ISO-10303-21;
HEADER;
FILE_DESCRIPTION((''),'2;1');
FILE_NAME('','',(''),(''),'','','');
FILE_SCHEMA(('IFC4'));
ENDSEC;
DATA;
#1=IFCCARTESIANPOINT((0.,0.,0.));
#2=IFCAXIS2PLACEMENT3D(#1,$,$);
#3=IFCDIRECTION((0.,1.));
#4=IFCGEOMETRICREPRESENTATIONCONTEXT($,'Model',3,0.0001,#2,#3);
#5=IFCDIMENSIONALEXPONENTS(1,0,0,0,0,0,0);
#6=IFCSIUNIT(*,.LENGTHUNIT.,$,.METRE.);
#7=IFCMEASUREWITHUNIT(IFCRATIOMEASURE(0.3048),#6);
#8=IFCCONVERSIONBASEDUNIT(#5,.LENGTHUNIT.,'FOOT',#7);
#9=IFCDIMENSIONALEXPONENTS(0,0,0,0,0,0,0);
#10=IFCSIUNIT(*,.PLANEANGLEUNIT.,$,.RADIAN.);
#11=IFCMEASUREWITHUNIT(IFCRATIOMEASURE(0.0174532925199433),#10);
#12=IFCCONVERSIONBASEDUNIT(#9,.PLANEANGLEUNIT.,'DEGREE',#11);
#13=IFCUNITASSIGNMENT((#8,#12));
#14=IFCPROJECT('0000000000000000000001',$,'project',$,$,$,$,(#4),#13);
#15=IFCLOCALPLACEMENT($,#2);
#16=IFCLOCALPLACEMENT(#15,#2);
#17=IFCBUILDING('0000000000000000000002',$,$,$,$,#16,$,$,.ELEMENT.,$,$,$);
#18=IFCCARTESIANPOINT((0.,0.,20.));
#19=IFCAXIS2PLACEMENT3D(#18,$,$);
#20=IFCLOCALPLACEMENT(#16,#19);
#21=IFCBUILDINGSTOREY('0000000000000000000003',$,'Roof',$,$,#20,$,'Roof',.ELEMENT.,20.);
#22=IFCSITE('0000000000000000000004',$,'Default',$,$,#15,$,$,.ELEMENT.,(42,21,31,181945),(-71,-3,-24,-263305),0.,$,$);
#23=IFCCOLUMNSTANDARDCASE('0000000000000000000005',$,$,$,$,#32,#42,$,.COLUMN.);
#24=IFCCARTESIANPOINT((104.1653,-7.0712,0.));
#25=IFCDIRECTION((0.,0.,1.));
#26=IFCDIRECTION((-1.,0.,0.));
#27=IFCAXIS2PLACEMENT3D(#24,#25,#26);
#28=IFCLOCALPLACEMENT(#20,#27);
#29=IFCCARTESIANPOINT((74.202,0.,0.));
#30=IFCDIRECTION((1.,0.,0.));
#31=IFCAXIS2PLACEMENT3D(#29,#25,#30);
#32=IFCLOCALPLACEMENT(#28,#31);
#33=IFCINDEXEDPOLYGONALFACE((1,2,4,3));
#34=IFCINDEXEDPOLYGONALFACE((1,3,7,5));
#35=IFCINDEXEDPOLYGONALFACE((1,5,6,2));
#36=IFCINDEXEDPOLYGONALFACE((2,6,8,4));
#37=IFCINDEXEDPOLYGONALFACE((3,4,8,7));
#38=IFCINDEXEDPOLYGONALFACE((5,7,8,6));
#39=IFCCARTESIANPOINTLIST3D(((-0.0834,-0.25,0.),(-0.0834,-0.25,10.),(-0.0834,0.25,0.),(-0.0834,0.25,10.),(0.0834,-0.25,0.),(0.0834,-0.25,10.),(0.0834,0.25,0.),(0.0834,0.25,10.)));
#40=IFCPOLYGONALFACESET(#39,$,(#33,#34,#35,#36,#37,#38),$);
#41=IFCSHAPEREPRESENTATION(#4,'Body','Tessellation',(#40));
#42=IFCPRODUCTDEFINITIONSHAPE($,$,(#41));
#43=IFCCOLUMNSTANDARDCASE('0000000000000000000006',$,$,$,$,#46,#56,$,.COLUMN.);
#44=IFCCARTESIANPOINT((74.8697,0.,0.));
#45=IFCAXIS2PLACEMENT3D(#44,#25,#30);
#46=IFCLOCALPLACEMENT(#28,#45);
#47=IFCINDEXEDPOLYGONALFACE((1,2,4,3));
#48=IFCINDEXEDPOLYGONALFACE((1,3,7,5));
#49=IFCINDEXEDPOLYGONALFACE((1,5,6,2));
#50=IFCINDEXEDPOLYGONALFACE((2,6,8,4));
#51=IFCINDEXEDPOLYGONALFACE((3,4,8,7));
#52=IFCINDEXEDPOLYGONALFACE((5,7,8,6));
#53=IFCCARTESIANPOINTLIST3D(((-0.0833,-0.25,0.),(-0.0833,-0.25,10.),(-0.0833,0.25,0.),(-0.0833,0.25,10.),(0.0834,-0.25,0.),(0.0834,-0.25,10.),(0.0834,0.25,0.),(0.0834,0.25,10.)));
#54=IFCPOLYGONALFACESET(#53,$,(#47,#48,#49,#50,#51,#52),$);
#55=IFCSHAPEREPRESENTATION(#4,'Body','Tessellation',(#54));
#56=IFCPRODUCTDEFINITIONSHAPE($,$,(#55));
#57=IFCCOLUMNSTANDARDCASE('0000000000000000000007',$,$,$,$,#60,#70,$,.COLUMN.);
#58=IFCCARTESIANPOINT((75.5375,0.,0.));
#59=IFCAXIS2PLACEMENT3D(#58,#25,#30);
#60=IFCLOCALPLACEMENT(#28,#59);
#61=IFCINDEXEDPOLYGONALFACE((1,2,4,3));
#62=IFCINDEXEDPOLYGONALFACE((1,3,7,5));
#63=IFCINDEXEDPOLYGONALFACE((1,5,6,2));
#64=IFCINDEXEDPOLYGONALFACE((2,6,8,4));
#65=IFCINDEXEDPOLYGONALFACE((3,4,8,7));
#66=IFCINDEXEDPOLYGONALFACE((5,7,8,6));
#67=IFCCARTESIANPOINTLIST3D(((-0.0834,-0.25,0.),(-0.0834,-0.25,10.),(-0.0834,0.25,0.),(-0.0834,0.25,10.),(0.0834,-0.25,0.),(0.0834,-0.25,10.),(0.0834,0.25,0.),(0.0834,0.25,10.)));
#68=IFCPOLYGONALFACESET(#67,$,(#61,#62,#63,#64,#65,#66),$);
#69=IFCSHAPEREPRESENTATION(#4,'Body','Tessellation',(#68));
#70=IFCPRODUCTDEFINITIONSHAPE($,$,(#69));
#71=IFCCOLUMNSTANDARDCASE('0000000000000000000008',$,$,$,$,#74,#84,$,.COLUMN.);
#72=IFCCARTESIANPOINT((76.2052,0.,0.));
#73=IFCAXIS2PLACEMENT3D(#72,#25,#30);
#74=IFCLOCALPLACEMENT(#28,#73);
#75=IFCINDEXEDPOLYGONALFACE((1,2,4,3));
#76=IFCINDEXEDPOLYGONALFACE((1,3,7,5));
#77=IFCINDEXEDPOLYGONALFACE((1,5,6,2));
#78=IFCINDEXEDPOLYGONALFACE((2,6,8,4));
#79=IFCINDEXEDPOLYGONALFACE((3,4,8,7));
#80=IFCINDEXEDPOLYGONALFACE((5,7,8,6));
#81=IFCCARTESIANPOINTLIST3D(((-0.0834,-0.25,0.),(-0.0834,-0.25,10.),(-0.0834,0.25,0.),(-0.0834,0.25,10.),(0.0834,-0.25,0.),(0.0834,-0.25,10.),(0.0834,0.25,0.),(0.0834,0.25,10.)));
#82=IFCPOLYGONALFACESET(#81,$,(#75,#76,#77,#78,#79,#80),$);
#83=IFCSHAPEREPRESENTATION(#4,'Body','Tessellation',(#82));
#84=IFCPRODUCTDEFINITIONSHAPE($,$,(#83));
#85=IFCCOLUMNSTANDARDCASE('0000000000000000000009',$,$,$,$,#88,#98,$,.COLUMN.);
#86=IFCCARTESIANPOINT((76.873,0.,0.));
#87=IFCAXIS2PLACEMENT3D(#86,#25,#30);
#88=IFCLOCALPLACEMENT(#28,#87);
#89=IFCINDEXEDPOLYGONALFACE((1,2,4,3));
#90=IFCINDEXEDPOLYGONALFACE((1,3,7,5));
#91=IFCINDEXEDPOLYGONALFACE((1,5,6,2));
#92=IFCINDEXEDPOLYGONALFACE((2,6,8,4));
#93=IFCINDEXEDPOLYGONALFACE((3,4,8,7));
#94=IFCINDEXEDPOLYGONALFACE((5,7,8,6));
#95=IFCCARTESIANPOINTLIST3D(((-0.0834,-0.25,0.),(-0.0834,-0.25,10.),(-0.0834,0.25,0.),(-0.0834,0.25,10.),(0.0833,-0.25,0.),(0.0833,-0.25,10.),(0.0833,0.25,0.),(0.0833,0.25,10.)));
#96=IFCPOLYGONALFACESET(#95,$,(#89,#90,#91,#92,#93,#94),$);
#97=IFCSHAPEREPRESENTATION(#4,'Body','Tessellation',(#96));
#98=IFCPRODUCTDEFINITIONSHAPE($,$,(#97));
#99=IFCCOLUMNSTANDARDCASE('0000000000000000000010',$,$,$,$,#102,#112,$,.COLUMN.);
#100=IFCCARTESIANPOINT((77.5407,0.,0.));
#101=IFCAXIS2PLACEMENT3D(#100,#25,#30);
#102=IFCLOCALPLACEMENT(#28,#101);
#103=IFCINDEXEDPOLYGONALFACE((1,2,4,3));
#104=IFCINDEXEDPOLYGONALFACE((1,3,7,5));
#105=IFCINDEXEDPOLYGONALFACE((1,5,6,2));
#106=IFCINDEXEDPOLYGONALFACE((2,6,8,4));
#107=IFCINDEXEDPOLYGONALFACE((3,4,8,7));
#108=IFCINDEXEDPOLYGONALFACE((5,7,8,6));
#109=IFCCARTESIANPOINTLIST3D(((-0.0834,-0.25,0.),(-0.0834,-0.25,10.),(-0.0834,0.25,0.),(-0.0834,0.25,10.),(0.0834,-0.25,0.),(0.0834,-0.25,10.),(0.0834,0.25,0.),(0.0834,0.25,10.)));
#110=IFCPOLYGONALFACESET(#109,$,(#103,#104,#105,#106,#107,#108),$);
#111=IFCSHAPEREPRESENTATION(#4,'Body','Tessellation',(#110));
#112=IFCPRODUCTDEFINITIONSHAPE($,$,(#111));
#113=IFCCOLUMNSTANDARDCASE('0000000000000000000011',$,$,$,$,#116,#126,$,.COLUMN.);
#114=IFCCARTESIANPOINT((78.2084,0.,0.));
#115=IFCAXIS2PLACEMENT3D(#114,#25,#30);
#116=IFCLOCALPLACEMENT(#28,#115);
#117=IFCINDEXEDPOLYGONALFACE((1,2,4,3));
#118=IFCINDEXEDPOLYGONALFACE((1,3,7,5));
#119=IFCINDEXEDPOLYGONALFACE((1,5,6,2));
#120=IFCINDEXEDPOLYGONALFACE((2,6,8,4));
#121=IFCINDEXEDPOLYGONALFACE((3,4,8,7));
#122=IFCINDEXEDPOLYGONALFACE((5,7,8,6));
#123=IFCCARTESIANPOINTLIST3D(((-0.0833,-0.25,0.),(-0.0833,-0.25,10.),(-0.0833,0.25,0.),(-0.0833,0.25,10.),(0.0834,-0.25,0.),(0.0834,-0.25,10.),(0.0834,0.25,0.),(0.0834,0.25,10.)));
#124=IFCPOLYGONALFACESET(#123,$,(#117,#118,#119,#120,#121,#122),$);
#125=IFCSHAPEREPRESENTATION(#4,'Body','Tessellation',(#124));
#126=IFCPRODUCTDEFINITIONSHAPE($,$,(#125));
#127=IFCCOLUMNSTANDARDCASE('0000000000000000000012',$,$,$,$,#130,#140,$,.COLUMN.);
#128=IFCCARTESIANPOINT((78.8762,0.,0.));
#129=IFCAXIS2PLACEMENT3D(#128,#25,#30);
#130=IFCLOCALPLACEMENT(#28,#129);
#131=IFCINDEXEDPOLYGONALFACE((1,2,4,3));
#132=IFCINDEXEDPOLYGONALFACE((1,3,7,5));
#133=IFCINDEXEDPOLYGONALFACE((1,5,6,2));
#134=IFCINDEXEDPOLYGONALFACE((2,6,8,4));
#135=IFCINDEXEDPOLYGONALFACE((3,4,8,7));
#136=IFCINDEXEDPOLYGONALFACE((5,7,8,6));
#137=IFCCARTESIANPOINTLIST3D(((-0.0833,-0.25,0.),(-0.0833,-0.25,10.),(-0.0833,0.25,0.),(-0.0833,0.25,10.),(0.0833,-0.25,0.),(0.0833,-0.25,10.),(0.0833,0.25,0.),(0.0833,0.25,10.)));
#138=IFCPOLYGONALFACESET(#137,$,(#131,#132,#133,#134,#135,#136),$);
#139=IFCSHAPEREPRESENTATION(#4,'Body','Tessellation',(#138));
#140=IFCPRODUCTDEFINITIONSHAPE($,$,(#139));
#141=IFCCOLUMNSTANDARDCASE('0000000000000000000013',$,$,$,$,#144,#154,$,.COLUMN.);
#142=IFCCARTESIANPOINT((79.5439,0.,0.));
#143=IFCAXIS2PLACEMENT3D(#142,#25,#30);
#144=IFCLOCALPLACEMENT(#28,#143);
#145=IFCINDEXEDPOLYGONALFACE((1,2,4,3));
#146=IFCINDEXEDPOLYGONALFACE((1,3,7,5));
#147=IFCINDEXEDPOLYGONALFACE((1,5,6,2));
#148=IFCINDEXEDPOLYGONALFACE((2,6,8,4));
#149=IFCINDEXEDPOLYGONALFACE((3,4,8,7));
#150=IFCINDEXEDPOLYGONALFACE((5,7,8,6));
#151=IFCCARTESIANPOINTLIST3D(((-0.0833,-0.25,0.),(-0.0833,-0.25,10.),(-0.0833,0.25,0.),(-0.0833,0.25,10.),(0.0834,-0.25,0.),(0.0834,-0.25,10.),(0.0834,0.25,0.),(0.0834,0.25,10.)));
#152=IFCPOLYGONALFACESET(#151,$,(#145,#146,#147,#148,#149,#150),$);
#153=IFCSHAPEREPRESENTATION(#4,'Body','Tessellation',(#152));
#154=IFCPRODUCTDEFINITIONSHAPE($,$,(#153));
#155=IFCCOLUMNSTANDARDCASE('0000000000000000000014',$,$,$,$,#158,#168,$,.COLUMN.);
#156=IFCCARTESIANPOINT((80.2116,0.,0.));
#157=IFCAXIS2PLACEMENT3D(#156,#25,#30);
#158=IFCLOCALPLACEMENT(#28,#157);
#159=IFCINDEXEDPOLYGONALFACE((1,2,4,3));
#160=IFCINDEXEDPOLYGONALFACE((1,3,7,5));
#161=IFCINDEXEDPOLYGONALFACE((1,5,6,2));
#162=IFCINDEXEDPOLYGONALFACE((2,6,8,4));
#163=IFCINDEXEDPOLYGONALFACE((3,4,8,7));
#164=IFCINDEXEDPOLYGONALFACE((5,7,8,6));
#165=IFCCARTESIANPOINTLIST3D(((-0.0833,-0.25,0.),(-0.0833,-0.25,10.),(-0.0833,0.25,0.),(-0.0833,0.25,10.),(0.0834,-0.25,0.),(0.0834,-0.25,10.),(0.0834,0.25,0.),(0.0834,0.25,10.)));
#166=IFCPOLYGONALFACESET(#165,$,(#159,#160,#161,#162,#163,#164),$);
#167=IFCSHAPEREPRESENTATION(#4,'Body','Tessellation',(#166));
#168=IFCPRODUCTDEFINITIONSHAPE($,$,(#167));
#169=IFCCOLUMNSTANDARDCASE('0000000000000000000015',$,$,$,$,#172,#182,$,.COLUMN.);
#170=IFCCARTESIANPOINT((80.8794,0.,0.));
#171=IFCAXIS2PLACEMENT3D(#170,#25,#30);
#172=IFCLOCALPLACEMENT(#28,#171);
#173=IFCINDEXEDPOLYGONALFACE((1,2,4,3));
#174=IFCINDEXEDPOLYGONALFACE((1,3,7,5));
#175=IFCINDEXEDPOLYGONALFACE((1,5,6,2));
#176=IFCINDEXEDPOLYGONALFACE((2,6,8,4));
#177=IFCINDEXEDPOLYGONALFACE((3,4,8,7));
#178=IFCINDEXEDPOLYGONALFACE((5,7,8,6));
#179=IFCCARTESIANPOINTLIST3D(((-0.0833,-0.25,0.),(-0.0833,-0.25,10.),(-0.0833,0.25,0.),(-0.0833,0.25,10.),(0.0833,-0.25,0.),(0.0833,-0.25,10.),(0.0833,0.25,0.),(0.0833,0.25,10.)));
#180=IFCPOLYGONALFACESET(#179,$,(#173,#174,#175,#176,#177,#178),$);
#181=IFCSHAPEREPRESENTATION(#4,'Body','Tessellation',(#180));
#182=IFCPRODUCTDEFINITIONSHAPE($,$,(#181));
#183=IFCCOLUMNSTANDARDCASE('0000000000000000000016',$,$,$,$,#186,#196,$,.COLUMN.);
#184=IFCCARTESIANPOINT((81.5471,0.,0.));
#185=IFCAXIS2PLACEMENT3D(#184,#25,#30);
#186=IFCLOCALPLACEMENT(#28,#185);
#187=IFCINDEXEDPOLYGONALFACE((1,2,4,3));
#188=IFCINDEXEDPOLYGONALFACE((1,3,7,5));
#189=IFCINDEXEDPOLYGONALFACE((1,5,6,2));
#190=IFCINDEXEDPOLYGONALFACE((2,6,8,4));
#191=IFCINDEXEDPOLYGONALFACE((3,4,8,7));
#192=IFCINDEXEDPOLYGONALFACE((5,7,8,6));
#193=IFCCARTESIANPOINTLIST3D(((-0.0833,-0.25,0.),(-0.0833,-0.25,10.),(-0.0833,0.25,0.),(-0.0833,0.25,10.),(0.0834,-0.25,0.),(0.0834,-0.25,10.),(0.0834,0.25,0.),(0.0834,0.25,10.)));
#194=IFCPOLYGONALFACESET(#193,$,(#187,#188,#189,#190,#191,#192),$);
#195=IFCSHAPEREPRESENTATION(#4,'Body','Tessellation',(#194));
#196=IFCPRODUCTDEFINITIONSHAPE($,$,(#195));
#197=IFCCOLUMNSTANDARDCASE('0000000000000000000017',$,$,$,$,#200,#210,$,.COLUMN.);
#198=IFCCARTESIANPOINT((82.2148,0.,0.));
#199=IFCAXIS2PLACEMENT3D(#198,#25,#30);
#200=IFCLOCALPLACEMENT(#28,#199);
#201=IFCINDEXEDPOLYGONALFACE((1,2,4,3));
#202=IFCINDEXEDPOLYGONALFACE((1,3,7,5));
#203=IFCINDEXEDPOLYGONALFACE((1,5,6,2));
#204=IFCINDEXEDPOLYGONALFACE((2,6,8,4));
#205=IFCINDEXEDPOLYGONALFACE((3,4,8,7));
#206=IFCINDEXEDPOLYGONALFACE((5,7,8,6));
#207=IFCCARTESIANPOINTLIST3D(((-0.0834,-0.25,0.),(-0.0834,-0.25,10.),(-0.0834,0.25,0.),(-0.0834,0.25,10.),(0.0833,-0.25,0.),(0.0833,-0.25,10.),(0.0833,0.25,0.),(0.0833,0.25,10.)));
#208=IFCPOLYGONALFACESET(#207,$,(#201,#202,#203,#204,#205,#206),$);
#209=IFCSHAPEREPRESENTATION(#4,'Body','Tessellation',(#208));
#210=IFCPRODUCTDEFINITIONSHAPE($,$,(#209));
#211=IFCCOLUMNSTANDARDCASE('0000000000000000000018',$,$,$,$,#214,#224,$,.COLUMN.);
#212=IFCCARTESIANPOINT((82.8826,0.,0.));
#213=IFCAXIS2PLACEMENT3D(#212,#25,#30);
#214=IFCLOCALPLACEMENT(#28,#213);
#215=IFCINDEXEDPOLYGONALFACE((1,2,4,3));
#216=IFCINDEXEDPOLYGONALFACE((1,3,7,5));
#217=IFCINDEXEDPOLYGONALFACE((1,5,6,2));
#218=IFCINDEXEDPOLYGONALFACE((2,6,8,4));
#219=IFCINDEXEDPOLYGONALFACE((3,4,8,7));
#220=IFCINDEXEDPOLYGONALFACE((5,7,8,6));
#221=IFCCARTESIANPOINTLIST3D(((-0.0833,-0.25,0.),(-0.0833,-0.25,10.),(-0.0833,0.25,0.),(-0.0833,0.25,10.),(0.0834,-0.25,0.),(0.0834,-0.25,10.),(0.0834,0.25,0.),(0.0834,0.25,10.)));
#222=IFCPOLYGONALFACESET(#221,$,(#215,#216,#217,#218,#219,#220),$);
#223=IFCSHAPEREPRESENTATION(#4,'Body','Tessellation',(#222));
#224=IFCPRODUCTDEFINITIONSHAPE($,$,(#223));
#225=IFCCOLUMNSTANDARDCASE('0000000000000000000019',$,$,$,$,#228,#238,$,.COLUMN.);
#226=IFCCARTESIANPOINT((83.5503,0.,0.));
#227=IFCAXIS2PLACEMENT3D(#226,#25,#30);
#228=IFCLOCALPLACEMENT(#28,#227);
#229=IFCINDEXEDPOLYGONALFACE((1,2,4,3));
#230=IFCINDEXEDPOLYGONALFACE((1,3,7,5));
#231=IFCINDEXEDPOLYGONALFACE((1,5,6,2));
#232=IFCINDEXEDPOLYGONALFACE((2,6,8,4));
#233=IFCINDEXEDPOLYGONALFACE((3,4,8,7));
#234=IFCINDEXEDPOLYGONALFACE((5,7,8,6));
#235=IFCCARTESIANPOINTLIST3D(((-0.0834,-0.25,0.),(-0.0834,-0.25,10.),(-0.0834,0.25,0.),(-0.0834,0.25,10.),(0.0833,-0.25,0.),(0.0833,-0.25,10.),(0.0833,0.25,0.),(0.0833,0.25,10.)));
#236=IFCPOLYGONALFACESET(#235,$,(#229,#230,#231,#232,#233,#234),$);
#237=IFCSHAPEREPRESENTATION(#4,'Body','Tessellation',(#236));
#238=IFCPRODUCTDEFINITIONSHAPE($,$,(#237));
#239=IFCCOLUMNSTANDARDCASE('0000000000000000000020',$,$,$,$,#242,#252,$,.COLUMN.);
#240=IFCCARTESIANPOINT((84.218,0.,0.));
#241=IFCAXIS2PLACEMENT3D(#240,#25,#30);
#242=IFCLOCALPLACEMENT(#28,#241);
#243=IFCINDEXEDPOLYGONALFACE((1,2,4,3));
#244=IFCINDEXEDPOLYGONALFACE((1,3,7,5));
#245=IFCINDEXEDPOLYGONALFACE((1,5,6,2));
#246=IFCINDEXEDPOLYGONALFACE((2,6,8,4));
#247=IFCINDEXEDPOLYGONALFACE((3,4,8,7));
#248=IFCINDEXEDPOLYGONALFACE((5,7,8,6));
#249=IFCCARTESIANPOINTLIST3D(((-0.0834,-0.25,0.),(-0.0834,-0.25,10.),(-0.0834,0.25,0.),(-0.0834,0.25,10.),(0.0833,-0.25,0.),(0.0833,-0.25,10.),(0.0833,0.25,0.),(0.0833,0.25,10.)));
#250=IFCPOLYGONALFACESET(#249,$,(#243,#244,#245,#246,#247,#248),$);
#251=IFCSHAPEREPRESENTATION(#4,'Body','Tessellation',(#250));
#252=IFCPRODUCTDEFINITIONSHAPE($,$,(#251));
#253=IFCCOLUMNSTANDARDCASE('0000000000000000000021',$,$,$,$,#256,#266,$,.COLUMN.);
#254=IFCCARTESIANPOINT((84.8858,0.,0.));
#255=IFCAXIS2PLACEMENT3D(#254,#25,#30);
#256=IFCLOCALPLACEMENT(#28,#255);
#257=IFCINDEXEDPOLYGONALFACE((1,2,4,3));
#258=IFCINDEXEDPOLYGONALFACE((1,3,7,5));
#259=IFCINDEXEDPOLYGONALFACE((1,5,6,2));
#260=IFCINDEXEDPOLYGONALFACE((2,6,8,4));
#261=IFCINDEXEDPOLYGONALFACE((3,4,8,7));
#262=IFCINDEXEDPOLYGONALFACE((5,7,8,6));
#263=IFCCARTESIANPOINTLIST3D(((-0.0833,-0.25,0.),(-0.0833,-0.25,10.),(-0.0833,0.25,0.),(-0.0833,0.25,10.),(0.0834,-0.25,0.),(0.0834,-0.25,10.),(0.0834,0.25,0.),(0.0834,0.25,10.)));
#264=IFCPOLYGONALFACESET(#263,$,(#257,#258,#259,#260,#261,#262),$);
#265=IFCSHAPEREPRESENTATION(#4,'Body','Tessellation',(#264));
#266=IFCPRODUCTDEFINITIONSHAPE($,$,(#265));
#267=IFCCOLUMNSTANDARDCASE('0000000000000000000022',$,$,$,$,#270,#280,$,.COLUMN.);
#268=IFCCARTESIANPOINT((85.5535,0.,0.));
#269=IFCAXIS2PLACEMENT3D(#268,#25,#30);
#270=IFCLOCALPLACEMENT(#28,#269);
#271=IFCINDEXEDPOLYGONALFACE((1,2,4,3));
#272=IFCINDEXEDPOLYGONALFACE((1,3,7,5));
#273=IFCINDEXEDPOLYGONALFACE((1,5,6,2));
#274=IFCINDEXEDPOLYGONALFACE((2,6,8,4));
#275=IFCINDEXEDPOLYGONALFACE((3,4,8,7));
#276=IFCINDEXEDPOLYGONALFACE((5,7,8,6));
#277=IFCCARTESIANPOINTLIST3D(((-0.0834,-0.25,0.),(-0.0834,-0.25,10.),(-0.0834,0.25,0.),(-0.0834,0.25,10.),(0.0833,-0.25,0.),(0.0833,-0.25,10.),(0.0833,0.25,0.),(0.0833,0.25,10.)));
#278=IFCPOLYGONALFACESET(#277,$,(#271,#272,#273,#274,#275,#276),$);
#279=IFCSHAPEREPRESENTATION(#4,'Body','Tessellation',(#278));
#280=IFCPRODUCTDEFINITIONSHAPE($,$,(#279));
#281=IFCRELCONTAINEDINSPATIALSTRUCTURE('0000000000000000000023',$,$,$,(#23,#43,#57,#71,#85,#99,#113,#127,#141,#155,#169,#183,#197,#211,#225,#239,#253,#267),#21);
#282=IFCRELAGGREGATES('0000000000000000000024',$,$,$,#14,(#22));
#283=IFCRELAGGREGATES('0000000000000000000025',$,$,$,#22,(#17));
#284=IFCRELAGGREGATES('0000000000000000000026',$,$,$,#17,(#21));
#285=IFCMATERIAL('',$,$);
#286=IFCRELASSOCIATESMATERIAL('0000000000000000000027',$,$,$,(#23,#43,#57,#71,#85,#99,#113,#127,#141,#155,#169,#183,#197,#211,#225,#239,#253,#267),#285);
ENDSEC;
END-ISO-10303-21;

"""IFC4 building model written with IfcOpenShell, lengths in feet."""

from ifc_helpers import new_model, entity, si_unit, converted_unit, direction, frame, origin, place, context, project, spatial, rectangle, extrude, material, element, save


model = new_model("IFC4")

# Units and contexts
model_context = context("Model", 3, precision=0.0001, world=origin(), true_north=direction((0.0, 1.0)))
ifc_project = project(units=[converted_unit("LENGTHUNIT", "FOOT", entity("IfcRatioMeasure", 0.3048), si_unit("LENGTHUNIT", "METRE"), dimensions=[1, 0, 0, 0, 0, 0, 0]), converted_unit("PLANEANGLEUNIT", "DEGREE", entity("IfcRatioMeasure", 0.0174532925199433), si_unit("PLANEANGLEUNIT", "RADIAN"), dimensions=[0, 0, 0, 0, 0, 0, 0])], contexts=[model_context])

# Site, building, storey
site_placement = place(None, origin())
site = spatial("IfcSite", under=ifc_project, at=site_placement, Name="Default", CompositionType="ELEMENT", RefLatitude=(42, 21, 31, 181945), RefLongitude=(-71, -3, -24, -263305), RefElevation=0.0)
building_placement = place(site_placement, origin())
building = spatial("IfcBuilding", under=site, at=building_placement, CompositionType="ELEMENT")
storey_placement = place(building_placement, frame((0.0, 0.0, 20.0)))
storey = spatial("IfcBuildingStorey", under=building, at=storey_placement, Name="Roof", LongName="Roof", CompositionType="ELEMENT", Elevation=20.0)

# Columns
ifc_material_1 = material(Name="")
placement_1 = place(storey_placement, frame((104.1653, -7.0712, 0.0), z_axis=(0.0, 0.0, 1.0), x_axis=(-1.0, 0.0, 0.0)))
for number, where, z_axis, x_axis in (
    (1, (74.202, 0.0, 0.0), (0.0, 0.0, 1.0), (1.0, 0.0, 0.0)),
    (2, (74.8697, 0.0, 0.0), (0.0, 0.0, 1.0), (1.0, 0.0, 0.0)),
    (3, (75.5375, 0.0, 0.0), (0.0, 0.0, 1.0), (1.0, 0.0, 0.0)),
    (4, (76.2052, 0.0, 0.0), (0.0, 0.0, 1.0), (1.0, 0.0, 0.0)),
    (5, (76.873, 0.0, 0.0), (0.0, 0.0, 1.0), (1.0, 0.0, 0.0)),
    (6, (77.5407, 0.0, 0.0), (0.0, 0.0, 1.0), (1.0, 0.0, 0.0)),
    (7, (78.2084, 0.0, 0.0), (0.0, 0.0, 1.0), (1.0, 0.0, 0.0)),
    (8, (78.8762, 0.0, 0.0), (0.0, 0.0, 1.0), (1.0, 0.0, 0.0)),
    (9, (79.5439, 0.0, 0.0), (0.0, 0.0, 1.0), (1.0, 0.0, 0.0)),
    (10, (80.2116, 0.0, 0.0), (0.0, 0.0, 1.0), (1.0, 0.0, 0.0)),
    (11, (80.8794, 0.0, 0.0), (0.0, 0.0, 1.0), (1.0, 0.0, 0.0)),
    (12, (81.5471, 0.0, 0.0), (0.0, 0.0, 1.0), (1.0, 0.0, 0.0)),
    (13, (82.2148, 0.0, 0.0), (0.0, 0.0, 1.0), (1.0, 0.0, 0.0)),
    (14, (82.8826, 0.0, 0.0), (0.0, 0.0, 1.0), (1.0, 0.0, 0.0)),
    (15, (83.5503, 0.0, 0.0), (0.0, 0.0, 1.0), (1.0, 0.0, 0.0)),
    (16, (84.218, 0.0, 0.0), (0.0, 0.0, 1.0), (1.0, 0.0, 0.0)),
    (17, (84.8858, 0.0, 0.0), (0.0, 0.0, 1.0), (1.0, 0.0, 0.0)),
    (18, (85.5535, 0.0, 0.0), (0.0, 0.0, 1.0), (1.0, 0.0, 0.0)),
):
    element("IfcColumnStandardCase", number, at=place(placement_1, frame(where, z_axis=z_axis, x_axis=x_axis)), inside=storey, material=ifc_material_1, PredefinedType="COLUMN", context=model_context, shape_type="SweptSolid", body=[
        extrude(rectangle(XDim=0.1667, YDim=0.5), origin(), (0.0, 0.0, 1.0), 10.0),
    ])

save(model, "model.ifc")
